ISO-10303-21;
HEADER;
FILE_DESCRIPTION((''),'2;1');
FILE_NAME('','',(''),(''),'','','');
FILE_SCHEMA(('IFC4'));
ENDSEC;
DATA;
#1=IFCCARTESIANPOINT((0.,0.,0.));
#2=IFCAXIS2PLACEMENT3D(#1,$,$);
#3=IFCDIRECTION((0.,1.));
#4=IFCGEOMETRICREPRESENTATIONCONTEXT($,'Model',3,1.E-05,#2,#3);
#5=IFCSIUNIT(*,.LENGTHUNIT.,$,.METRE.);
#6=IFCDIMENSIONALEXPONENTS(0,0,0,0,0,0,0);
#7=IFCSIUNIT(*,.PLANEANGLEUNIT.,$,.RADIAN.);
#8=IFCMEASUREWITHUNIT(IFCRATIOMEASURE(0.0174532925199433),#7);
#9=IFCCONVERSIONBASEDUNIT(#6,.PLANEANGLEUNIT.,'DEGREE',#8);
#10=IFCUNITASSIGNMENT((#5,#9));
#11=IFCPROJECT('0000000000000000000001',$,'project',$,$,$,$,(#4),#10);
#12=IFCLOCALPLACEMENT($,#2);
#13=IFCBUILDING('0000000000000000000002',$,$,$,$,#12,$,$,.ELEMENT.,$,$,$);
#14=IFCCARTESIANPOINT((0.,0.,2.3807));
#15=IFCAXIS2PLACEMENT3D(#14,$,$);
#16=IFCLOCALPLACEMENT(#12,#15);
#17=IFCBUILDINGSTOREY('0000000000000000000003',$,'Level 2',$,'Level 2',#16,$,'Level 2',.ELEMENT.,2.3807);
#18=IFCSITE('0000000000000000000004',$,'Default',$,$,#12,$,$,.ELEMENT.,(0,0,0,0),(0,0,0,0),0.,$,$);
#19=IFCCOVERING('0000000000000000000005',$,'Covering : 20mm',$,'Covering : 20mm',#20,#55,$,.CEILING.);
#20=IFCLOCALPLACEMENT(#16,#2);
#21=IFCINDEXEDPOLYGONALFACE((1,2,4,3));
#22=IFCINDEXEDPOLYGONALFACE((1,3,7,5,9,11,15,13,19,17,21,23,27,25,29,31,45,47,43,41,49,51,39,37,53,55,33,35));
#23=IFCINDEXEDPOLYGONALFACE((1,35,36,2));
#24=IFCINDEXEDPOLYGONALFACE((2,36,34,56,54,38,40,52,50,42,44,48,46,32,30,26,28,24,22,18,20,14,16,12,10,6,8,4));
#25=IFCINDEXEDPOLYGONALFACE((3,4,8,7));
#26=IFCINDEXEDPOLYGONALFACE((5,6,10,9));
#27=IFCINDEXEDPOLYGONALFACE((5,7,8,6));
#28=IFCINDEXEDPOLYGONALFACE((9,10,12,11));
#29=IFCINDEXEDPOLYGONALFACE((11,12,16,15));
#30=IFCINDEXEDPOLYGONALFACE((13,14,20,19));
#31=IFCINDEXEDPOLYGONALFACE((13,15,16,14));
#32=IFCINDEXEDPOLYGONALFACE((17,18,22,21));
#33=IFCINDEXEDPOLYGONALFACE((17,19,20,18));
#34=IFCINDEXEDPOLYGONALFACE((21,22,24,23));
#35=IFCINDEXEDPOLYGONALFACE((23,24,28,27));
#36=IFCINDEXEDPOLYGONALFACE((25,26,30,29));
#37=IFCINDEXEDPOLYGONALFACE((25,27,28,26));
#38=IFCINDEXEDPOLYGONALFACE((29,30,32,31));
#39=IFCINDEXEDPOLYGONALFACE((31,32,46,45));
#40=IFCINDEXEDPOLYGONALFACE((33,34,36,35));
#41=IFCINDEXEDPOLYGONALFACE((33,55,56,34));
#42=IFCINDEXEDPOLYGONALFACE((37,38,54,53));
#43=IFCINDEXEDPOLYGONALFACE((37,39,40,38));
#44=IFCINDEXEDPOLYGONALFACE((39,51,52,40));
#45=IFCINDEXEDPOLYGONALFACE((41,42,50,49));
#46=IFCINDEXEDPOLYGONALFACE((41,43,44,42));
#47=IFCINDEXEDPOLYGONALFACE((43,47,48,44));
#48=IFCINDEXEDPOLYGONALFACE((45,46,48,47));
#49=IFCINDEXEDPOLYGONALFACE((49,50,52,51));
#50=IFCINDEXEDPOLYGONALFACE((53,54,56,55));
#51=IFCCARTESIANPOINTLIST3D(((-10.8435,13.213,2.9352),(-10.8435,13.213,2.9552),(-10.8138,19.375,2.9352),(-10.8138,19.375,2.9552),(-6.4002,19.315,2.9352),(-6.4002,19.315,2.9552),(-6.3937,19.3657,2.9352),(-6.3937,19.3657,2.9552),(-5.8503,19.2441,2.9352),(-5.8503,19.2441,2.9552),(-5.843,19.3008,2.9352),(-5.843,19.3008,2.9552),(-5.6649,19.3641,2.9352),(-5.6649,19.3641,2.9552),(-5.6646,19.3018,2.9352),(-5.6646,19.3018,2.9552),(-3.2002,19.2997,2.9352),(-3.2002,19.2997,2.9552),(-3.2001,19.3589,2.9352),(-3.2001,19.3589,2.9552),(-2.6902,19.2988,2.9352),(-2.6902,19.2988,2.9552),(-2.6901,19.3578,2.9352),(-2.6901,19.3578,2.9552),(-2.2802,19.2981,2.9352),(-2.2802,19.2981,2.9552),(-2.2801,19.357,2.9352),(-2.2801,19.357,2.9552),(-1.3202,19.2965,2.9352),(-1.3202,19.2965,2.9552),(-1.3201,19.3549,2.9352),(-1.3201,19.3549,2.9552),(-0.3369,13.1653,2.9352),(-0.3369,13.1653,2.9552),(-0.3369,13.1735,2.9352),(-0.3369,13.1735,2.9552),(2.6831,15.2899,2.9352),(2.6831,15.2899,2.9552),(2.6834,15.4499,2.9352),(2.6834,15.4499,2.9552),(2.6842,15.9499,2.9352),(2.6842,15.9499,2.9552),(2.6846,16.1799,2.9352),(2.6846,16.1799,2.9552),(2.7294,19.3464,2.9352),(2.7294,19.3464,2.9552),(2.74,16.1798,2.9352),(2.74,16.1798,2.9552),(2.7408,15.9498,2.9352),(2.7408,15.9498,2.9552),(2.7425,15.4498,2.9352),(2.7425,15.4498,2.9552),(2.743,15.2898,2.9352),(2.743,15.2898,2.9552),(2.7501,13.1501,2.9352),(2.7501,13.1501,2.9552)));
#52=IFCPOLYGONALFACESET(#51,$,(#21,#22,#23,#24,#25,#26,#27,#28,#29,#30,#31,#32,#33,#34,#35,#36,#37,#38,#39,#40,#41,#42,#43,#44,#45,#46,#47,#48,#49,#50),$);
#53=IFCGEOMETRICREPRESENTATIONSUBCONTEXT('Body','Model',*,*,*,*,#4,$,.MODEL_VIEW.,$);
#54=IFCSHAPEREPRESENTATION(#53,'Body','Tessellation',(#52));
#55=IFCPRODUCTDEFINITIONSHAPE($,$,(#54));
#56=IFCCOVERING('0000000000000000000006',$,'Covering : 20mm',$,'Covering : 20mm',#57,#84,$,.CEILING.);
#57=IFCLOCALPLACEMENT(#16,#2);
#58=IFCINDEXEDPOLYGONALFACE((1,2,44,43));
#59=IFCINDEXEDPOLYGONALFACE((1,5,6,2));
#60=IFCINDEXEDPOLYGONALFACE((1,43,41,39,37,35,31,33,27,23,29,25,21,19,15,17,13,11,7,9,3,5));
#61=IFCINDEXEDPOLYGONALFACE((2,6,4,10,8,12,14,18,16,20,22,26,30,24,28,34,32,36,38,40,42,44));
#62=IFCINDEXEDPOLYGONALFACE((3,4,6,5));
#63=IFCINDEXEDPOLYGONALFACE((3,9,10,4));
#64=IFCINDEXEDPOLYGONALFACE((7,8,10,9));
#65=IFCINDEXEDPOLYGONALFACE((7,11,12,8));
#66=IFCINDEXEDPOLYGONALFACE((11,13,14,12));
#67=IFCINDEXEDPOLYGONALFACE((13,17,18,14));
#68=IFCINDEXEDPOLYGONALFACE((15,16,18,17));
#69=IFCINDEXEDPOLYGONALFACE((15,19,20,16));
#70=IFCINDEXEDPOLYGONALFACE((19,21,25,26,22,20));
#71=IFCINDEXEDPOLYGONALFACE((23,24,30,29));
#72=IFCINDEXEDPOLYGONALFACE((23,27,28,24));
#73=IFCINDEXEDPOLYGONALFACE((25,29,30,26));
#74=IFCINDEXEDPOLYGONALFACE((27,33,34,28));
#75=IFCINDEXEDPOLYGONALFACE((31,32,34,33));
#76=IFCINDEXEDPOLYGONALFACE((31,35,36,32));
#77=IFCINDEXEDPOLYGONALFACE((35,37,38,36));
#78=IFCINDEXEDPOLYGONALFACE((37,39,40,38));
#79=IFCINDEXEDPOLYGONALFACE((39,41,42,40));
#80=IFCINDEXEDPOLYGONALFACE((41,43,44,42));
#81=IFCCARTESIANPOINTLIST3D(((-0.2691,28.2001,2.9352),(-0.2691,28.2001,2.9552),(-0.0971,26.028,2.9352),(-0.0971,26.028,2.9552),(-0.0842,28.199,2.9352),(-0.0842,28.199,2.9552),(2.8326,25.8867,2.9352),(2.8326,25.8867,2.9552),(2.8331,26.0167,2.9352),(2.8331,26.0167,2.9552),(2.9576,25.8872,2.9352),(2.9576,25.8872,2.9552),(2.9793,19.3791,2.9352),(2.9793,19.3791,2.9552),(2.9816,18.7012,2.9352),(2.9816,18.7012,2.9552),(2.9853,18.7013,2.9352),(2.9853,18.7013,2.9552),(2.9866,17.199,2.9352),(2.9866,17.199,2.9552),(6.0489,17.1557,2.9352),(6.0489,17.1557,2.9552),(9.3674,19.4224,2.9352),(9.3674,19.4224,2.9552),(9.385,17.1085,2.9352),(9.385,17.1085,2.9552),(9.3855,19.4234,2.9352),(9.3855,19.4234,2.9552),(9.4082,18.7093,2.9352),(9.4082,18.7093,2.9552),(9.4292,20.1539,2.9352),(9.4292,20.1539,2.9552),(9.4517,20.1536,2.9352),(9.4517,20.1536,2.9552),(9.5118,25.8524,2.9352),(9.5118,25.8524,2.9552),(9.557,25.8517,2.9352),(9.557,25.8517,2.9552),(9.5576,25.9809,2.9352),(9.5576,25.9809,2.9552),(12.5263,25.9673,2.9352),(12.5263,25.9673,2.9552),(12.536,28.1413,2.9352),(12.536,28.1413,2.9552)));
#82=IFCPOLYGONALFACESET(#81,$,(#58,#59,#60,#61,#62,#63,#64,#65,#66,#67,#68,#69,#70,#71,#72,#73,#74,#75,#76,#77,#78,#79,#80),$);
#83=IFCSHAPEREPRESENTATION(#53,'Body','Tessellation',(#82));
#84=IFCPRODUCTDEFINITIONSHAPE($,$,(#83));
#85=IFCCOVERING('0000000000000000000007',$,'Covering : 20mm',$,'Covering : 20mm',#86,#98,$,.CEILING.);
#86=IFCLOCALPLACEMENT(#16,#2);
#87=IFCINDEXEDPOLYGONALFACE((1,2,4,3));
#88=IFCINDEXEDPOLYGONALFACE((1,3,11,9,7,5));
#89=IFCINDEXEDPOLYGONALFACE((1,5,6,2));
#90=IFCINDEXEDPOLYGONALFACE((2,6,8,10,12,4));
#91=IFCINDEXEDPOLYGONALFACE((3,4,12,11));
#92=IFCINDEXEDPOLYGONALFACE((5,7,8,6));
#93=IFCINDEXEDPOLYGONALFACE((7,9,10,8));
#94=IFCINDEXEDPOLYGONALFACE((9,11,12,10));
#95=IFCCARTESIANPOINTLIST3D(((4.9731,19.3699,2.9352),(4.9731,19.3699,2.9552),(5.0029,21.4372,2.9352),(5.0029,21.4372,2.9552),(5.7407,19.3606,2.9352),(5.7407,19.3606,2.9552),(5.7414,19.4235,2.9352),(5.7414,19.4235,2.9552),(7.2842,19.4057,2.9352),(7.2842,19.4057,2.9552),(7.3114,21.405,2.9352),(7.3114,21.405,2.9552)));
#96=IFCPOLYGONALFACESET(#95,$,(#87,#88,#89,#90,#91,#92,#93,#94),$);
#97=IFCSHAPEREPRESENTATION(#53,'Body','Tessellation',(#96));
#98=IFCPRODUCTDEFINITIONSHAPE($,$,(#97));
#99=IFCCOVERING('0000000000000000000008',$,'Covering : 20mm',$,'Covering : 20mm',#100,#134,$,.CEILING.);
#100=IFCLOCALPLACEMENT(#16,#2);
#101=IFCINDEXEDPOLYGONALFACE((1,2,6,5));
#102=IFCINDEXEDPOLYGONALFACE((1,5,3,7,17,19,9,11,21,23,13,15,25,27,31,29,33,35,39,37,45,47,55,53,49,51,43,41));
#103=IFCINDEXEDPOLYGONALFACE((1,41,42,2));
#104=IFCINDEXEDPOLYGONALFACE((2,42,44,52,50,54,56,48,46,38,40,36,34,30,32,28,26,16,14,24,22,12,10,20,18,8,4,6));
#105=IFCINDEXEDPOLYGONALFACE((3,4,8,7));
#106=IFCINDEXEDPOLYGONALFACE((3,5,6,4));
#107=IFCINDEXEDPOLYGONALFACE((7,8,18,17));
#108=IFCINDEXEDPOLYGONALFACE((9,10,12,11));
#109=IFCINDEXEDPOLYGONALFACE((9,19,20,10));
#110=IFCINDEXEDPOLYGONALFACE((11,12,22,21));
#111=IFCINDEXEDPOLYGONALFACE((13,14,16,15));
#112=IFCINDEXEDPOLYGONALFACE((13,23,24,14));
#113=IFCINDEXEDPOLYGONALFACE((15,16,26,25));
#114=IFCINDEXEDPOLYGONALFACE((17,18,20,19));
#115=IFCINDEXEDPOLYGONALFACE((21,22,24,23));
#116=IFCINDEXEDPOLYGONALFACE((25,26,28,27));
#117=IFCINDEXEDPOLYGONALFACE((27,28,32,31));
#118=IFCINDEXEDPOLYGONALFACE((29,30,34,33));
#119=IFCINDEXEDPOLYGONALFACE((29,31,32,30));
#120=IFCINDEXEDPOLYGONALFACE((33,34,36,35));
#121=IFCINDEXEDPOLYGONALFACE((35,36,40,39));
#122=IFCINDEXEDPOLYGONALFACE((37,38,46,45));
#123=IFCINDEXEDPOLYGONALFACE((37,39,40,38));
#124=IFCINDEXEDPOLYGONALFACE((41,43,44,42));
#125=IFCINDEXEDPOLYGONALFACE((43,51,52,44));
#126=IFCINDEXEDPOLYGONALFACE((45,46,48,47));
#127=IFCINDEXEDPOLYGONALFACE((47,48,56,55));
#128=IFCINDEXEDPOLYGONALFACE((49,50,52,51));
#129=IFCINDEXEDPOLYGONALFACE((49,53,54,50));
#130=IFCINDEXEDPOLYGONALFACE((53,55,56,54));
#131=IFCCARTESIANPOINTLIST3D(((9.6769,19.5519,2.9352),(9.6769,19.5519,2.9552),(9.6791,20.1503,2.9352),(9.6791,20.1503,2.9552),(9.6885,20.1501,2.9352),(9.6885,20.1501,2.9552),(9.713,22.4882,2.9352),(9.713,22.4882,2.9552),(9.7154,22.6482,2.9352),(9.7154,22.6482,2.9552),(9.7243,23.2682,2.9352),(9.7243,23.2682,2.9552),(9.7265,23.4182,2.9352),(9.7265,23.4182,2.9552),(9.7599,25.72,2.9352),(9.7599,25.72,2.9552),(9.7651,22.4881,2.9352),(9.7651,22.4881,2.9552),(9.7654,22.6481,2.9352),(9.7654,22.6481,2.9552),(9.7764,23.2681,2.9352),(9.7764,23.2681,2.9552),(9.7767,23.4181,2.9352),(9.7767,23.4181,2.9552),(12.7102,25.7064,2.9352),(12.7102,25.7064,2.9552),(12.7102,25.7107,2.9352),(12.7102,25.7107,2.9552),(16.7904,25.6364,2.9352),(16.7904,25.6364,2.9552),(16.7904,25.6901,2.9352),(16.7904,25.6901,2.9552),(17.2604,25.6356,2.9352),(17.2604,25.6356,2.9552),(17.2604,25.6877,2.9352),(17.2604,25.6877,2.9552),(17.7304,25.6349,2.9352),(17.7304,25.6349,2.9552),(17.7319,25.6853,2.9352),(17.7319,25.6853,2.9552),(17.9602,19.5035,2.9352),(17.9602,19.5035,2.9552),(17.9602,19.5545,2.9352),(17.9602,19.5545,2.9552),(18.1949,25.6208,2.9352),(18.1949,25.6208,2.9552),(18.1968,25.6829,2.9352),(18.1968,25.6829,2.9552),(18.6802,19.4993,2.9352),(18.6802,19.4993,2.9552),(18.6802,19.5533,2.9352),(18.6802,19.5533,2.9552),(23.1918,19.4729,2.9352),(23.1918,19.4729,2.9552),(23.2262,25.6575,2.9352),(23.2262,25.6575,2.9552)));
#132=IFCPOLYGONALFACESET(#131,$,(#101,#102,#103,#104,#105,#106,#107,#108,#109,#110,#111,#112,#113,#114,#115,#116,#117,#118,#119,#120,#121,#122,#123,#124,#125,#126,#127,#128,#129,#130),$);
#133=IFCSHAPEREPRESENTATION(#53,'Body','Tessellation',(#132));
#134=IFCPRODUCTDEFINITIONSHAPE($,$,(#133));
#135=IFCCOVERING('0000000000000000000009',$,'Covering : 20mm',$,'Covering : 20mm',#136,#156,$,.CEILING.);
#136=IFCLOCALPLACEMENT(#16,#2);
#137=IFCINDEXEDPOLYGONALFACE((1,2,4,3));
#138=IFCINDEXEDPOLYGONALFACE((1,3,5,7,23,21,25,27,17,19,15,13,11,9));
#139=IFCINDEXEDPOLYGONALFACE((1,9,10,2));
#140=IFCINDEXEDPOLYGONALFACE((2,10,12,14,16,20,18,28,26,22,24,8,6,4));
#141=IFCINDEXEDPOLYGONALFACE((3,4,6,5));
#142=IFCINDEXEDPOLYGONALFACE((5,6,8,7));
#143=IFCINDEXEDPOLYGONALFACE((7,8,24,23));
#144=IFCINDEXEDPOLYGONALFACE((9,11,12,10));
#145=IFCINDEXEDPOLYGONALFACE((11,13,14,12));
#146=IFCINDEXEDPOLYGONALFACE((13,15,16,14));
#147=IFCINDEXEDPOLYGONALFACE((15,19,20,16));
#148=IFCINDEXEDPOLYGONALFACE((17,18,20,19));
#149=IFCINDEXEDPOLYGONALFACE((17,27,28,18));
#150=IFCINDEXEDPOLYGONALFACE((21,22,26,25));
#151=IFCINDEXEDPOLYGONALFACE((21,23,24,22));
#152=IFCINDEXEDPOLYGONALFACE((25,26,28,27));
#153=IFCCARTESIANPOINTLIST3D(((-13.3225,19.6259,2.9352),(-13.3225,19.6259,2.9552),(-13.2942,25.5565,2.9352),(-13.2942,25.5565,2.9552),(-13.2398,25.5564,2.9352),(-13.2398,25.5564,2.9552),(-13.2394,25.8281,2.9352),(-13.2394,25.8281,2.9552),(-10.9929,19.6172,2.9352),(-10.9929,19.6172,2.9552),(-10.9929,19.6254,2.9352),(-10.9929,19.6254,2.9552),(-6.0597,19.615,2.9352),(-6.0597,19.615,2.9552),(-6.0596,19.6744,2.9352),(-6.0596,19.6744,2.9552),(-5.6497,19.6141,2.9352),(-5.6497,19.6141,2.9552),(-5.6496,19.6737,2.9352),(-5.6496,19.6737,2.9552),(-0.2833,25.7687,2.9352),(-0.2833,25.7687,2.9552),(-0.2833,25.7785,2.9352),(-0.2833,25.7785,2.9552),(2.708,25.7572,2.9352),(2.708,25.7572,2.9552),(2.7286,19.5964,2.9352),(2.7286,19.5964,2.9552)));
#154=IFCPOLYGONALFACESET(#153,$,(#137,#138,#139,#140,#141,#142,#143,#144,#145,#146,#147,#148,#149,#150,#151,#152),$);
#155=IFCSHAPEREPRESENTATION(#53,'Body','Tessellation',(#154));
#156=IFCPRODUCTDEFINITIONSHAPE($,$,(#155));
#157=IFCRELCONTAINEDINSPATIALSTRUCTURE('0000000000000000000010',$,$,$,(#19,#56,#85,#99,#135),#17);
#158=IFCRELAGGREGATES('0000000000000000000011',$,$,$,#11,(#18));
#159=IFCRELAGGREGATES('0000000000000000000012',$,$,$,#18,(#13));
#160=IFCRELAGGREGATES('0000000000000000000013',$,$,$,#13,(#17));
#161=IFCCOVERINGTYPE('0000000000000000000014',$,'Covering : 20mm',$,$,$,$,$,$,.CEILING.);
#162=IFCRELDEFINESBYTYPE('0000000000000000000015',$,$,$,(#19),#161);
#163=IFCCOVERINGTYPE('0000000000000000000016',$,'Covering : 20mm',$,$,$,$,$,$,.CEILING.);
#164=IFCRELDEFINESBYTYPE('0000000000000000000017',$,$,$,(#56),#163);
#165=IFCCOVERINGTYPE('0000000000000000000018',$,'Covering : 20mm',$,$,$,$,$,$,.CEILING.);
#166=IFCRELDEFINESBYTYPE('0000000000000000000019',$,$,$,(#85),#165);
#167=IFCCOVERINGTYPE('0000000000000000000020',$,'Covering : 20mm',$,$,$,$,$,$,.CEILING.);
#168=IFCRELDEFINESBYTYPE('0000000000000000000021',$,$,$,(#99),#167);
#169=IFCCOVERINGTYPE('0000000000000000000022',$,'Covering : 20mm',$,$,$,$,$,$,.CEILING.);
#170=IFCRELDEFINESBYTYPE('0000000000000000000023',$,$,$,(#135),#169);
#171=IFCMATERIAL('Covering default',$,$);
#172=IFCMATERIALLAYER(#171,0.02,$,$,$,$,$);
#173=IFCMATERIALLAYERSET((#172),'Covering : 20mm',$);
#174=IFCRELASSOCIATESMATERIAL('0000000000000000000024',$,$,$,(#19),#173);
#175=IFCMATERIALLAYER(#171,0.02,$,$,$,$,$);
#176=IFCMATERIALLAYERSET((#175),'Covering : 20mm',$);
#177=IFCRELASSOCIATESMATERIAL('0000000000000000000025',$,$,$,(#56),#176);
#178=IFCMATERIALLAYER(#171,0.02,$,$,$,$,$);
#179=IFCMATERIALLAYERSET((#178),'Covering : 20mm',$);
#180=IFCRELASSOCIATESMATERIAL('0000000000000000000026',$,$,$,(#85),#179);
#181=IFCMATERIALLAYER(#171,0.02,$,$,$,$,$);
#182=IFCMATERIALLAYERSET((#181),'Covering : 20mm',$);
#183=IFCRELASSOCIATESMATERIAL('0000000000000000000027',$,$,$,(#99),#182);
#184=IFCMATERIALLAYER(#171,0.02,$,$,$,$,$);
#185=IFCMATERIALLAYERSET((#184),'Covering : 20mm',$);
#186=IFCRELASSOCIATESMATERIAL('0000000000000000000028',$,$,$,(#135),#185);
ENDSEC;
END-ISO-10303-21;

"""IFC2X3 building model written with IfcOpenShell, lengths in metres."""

from ifc_helpers import new_model, entity, si_unit, converted_unit, direction, frame, origin, origin_with_axes, place, context, subcontext, project, spatial, polyline, outline, extrude, material, layer, layer_set, layer_usage, type_object, element, save


model = new_model("IFC2X3")

# Units and contexts
model_context = context("Model", 3, precision=1e-05, world=origin(), true_north=direction((0.0, 1.0)))
body_context = subcontext(model_context, "Body", "Model", "MODEL_VIEW")
ifc_project = project(units=[si_unit("LENGTHUNIT", "METRE"), converted_unit("PLANEANGLEUNIT", "DEGREE", entity("IfcRatioMeasure", 0.0174532925199433), si_unit("PLANEANGLEUNIT", "RADIAN"), dimensions=[0, 0, 0, 0, 0, 0, 0])], contexts=[model_context])

# Site, building, storey
placement = place(None, origin())
site = spatial("IfcSite", under=ifc_project, at=placement, Name="Default", CompositionType="ELEMENT", RefLatitude=(0, 0, 0, 0), RefLongitude=(0, 0, 0, 0), RefElevation=0.0)
building = spatial("IfcBuilding", under=site, at=placement, CompositionType="ELEMENT")
storey_placement = place(placement, frame((0.0, 0.0, 2.3807)))
storey = spatial("IfcBuildingStorey", under=building, at=storey_placement, Name="Level 2", ObjectType="Level 2", LongName="Level 2", CompositionType="ELEMENT", Elevation=2.3807)

# Coverings
ifc_material_1 = material(Name="Covering default")
ifc_layer_1 = layer(ifc_material_1, 0.02)
ifc_layer_set_1 = layer_set([ifc_layer_1], Name="Covering : 20mm")
ifc_layer_usage_1 = layer_usage(ifc_layer_set_1, "AXIS3", "POSITIVE", 0.0)
covering_type_1 = type_object("IfcCoveringType", Name="Covering : 20mm", PredefinedType="CEILING")
covering_1_placement = place(placement, frame((0.0, 0.0, 5.3159)))
element("IfcCovering", 1, at=covering_1_placement, inside=storey, type_object=covering_type_1, material=ifc_layer_usage_1, Name="Covering : 20mm", ObjectType="Covering : 20mm", PredefinedType="CEILING", context=body_context, shape_type="SweptSolid", body=[
    extrude(outline(polyline([(-10.8138, 19.375), (-6.3937, 19.3657), (-6.4002, 19.315), (-5.8503, 19.2441), (-5.843, 19.3008), (-5.6646, 19.3018), (-5.6649, 19.3641), (-3.2001, 19.3589), (-3.2002, 19.2997), (-2.6902, 19.2988), (-2.6901, 19.3578), (-2.2801, 19.357), (-2.2802, 19.2981), (-1.3202, 19.2965), (-1.3201, 19.3549), (2.7294, 19.3464), (2.74, 16.1798), (2.6846, 16.1799), (2.6842, 15.9499), (2.7408, 15.9498), (2.7425, 15.4498), (2.6834, 15.4499), (2.6831, 15.2899), (2.743, 15.2898), (2.7501, 13.1501), (-0.3369, 13.1653), (-0.3369, 13.1735), (-10.8435, 13.213), (-10.8138, 19.375)])), origin_with_axes(), (0.0, 0.0, 1.0), 0.02),
])
ifc_layer_2 = layer(ifc_material_1, 0.02)
ifc_layer_set_2 = layer_set([ifc_layer_2], Name="Covering : 20mm")
ifc_layer_usage_2 = layer_usage(ifc_layer_set_2, "AXIS3", "POSITIVE", 0.0)
covering_type_2 = type_object("IfcCoveringType", Name="Covering : 20mm", PredefinedType="CEILING")
covering_2_placement = place(placement, frame((0.0, 0.0, 5.3159)))
element("IfcCovering", 2, at=covering_2_placement, inside=storey, type_object=covering_type_2, material=ifc_layer_usage_2, Name="Covering : 20mm", ObjectType="Covering : 20mm", PredefinedType="CEILING", context=body_context, shape_type="SweptSolid", body=[
    extrude(outline(polyline([(-0.0842, 28.199), (-0.2691, 28.2001), (12.536, 28.1413), (12.5263, 25.9673), (9.5576, 25.9809), (9.557, 25.8517), (9.5118, 25.8524), (9.4292, 20.1539), (9.4517, 20.1536), (9.3855, 19.4234), (9.3674, 19.4224), (9.4082, 18.7093), (9.385, 17.1085), (6.0489, 17.1557), (6.0489, 17.1557), (2.9866, 17.199), (2.9816, 18.7012), (2.9853, 18.7013), (2.9793, 19.3791), (2.9793, 19.3791), (2.9793, 19.3791), (2.9576, 25.8872), (2.8326, 25.8867), (2.8331, 26.0167), (-0.0971, 26.028), (-0.0842, 28.199)])), origin_with_axes(), (0.0, 0.0, 1.0), 0.02),
])
ifc_layer_3 = layer(ifc_material_1, 0.02)
ifc_layer_set_3 = layer_set([ifc_layer_3], Name="Covering : 20mm")
ifc_layer_usage_3 = layer_usage(ifc_layer_set_3, "AXIS3", "POSITIVE", 0.0)
covering_type_3 = type_object("IfcCoveringType", Name="Covering : 20mm", PredefinedType="CEILING")
covering_3_placement = place(placement, frame((0.0, 0.0, 5.3159)))
element("IfcCovering", 3, at=covering_3_placement, inside=storey, type_object=covering_type_3, material=ifc_layer_usage_3, Name="Covering : 20mm", ObjectType="Covering : 20mm", PredefinedType="CEILING", context=body_context, shape_type="SweptSolid", body=[
    extrude(outline(polyline([(5.0029, 21.4372), (7.3114, 21.405), (7.2842, 19.4057), (5.7414, 19.4235), (5.7407, 19.3606), (4.9731, 19.3699), (5.0029, 21.4372)])), origin_with_axes(), (0.0, 0.0, 1.0), 0.02),
])
ifc_layer_4 = layer(ifc_material_1, 0.02)
ifc_layer_set_4 = layer_set([ifc_layer_4], Name="Covering : 20mm")
ifc_layer_usage_4 = layer_usage(ifc_layer_set_4, "AXIS3", "POSITIVE", 0.0)
covering_type_4 = type_object("IfcCoveringType", Name="Covering : 20mm", PredefinedType="CEILING")
covering_4_placement = place(placement, frame((0.0, 0.0, 5.3159)))
element("IfcCovering", 4, at=covering_4_placement, inside=storey, type_object=covering_type_4, material=ifc_layer_usage_4, Name="Covering : 20mm", ObjectType="Covering : 20mm", PredefinedType="CEILING", context=body_context, shape_type="SweptSolid", body=[
    extrude(outline(polyline([(9.6885, 20.1501), (9.6791, 20.1503), (9.713, 22.4882), (9.7651, 22.4881), (9.7654, 22.6481), (9.7154, 22.6482), (9.7243, 23.2682), (9.7764, 23.2681), (9.7767, 23.4181), (9.7265, 23.4182), (9.7599, 25.72), (12.7102, 25.7064), (12.7102, 25.7107), (16.7904, 25.6901), (16.7904, 25.6364), (17.2604, 25.6356), (17.2604, 25.6877), (17.7319, 25.6853), (17.7304, 25.6349), (18.1949, 25.6208), (18.1968, 25.6829), (23.2262, 25.6575), (23.1918, 19.4729), (18.6802, 19.4993), (18.6802, 19.5533), (17.9602, 19.5545), (17.9602, 19.5035), (9.6769, 19.5519), (9.6885, 20.1501)])), origin_with_axes(), (0.0, 0.0, 1.0), 0.02),
])
ifc_layer_5 = layer(ifc_material_1, 0.02)
ifc_layer_set_5 = layer_set([ifc_layer_5], Name="Covering : 20mm")
ifc_layer_usage_5 = layer_usage(ifc_layer_set_5, "AXIS3", "POSITIVE", 0.0)
covering_type_5 = type_object("IfcCoveringType", Name="Covering : 20mm", PredefinedType="CEILING")
covering_5_placement = place(placement, frame((0.0, 0.0, 5.3159)))
element("IfcCovering", 5, at=covering_5_placement, inside=storey, type_object=covering_type_5, material=ifc_layer_usage_5, Name="Covering : 20mm", ObjectType="Covering : 20mm", PredefinedType="CEILING", context=body_context, shape_type="SweptSolid", body=[
    extrude(outline(polyline([(-13.2942, 25.5565), (-13.2398, 25.5564), (-13.2394, 25.8281), (-0.2833, 25.7785), (-0.2833, 25.7687), (-0.2833, 25.7687), (-0.2833, 25.7687), (2.708, 25.7572), (2.7286, 19.5964), (-5.6497, 19.6141), (-5.6496, 19.6737), (-6.0596, 19.6744), (-6.0597, 19.615), (-10.9929, 19.6254), (-10.9929, 19.6172), (-13.3225, 19.6259), (-13.2942, 25.5565)])), origin_with_axes(), (0.0, 0.0, 1.0), 0.02),
])

save(model, "model.ifc")
